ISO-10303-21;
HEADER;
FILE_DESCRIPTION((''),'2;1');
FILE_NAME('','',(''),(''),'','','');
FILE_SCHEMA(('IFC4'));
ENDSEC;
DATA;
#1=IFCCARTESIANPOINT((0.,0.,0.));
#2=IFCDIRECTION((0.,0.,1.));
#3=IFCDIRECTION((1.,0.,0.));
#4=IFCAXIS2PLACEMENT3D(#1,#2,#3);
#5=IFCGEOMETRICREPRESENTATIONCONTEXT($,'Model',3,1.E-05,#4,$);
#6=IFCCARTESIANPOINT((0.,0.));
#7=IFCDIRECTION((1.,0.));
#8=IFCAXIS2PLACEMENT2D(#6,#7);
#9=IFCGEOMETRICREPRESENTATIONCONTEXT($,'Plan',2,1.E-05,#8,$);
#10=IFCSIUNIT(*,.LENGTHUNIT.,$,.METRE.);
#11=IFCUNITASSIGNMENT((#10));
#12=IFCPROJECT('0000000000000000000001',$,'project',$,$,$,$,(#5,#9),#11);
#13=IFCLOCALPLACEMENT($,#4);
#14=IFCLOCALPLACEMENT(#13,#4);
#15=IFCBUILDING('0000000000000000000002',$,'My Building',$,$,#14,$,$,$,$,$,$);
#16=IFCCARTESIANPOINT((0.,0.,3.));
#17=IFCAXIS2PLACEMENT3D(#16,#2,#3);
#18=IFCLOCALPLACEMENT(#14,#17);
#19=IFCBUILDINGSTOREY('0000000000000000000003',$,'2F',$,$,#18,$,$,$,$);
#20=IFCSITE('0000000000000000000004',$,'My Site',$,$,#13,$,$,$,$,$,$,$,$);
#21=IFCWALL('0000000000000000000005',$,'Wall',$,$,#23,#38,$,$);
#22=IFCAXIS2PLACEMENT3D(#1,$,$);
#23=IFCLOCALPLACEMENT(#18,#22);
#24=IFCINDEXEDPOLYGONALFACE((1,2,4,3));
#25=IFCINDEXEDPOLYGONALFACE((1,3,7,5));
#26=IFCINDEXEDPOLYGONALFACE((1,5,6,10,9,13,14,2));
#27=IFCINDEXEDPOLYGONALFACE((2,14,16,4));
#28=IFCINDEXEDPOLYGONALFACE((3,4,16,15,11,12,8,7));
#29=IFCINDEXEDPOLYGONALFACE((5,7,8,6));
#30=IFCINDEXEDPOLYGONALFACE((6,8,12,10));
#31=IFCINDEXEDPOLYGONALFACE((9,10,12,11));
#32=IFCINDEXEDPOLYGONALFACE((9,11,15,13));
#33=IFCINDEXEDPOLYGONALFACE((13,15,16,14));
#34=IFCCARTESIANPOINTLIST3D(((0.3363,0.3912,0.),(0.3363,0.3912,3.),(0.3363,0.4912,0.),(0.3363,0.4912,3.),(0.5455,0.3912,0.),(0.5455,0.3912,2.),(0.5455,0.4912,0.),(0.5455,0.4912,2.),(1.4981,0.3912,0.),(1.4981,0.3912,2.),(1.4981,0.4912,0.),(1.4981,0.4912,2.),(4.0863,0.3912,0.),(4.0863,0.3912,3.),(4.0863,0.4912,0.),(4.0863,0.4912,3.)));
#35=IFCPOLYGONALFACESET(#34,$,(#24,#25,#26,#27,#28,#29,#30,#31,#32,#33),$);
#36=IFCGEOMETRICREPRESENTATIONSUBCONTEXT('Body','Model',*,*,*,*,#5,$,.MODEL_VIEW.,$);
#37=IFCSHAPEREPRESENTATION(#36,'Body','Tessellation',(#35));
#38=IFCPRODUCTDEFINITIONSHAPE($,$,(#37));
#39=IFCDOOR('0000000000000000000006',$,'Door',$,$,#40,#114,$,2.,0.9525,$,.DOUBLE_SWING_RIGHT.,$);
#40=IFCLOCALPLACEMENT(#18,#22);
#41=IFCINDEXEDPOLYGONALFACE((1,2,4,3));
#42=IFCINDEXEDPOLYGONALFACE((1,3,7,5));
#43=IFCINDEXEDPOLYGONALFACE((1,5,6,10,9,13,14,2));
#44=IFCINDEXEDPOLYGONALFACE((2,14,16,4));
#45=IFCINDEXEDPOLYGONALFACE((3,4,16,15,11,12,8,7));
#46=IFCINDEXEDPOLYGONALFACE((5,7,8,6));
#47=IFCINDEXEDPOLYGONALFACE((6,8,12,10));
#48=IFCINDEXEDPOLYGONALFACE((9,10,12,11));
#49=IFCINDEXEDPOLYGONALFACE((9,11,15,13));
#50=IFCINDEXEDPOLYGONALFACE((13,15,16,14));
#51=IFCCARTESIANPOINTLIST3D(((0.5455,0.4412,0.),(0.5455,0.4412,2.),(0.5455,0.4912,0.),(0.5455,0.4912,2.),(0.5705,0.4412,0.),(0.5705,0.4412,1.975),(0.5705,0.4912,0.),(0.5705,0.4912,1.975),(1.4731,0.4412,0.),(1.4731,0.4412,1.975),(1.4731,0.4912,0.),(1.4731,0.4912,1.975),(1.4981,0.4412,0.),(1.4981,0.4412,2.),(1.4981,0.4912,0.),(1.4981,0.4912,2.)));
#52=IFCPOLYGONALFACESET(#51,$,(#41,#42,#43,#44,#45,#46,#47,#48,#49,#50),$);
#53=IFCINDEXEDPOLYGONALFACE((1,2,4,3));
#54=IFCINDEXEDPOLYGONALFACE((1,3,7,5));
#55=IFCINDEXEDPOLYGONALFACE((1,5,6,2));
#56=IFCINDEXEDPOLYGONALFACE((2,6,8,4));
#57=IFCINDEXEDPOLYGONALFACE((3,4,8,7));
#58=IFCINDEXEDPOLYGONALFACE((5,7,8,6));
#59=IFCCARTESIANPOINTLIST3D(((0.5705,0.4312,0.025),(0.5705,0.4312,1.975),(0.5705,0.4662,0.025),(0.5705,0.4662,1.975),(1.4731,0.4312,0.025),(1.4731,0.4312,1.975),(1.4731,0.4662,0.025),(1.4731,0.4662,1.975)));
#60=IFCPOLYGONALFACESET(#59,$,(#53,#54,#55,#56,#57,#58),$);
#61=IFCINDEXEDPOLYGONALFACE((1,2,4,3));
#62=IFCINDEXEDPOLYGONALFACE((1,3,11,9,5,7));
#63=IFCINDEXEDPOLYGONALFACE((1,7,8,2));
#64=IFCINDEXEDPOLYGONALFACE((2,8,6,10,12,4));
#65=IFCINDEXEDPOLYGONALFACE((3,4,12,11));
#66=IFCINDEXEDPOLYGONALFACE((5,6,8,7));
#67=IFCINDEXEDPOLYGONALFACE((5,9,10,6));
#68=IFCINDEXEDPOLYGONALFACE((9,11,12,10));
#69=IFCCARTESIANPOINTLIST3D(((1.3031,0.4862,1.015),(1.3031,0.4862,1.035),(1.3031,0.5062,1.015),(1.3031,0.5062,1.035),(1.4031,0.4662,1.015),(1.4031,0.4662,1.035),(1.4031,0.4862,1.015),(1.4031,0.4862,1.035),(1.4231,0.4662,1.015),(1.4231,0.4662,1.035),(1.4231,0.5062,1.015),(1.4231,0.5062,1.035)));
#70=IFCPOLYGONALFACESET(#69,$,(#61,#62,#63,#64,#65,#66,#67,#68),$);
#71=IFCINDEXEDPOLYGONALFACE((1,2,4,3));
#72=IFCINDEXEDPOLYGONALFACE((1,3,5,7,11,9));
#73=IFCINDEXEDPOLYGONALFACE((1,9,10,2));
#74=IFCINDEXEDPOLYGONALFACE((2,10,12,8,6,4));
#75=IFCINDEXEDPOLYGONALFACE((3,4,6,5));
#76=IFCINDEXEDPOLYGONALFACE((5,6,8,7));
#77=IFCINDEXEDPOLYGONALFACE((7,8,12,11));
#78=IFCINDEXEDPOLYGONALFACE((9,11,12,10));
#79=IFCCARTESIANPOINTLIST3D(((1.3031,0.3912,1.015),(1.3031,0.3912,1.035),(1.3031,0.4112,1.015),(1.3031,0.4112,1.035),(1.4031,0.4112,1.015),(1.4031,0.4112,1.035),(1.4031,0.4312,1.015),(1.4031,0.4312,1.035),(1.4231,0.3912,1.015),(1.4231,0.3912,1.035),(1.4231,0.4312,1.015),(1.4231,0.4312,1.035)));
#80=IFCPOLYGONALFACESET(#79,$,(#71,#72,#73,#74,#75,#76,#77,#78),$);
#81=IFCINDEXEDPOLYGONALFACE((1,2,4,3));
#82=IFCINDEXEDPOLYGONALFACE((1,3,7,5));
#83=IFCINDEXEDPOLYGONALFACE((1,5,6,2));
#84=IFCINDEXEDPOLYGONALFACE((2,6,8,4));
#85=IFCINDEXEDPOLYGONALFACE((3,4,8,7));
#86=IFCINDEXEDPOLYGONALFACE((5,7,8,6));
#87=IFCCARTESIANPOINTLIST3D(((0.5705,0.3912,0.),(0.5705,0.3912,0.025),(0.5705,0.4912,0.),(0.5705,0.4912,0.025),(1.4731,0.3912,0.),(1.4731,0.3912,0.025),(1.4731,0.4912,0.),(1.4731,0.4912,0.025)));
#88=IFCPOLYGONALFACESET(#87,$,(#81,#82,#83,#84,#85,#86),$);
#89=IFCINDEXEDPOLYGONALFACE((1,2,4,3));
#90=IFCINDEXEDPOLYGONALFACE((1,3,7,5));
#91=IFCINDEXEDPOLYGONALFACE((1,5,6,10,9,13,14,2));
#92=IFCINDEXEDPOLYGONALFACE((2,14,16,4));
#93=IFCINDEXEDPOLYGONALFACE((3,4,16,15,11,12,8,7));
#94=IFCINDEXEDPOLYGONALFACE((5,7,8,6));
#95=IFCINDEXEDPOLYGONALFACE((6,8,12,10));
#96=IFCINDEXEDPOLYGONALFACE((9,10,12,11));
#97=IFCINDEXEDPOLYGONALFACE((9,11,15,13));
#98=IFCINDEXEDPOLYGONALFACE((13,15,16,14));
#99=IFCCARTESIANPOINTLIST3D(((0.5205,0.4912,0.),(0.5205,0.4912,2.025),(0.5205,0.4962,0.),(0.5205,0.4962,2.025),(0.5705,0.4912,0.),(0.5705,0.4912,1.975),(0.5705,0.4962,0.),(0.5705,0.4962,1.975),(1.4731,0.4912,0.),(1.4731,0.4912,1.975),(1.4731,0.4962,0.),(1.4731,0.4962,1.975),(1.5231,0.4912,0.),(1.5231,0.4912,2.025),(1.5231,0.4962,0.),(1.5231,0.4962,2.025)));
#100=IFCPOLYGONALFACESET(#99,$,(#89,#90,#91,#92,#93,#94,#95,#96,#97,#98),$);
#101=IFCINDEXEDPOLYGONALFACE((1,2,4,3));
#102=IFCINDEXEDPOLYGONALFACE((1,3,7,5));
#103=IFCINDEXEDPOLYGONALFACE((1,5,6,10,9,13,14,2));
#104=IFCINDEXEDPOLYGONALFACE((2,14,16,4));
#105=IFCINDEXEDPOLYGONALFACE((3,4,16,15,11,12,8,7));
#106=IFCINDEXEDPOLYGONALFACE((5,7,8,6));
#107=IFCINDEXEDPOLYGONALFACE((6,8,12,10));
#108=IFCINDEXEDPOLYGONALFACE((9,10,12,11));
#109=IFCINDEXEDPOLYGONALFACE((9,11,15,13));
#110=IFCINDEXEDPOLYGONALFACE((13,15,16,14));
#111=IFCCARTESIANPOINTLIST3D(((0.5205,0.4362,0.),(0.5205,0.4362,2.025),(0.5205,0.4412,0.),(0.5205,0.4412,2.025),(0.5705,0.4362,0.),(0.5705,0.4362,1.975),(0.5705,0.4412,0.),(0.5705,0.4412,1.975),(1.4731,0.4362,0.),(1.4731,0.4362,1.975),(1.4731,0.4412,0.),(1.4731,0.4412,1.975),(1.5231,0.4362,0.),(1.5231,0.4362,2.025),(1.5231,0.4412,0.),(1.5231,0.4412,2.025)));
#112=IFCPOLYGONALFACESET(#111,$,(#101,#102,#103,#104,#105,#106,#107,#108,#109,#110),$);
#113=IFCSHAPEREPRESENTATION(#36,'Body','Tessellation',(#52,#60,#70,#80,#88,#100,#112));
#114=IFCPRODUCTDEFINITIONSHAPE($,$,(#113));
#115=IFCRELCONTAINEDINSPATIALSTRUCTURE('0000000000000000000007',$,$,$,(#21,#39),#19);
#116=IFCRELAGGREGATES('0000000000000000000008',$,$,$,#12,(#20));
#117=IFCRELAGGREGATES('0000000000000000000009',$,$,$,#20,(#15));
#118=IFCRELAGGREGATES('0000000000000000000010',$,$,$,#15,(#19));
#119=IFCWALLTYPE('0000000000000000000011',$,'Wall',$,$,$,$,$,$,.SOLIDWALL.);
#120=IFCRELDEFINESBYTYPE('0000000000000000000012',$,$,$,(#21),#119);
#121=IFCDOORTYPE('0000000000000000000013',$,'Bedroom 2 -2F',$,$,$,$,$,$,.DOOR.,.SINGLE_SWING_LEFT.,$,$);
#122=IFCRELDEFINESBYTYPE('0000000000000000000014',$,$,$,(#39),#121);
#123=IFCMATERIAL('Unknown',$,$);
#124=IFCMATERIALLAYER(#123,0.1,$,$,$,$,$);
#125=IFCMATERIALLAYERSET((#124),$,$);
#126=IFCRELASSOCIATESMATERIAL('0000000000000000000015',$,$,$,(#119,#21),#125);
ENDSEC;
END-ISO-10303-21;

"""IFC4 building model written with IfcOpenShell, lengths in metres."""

from ifc_helpers import new_model, entity, si_unit, frame, origin_with_axes, origin_2d_with_axis, place, context, subcontext, project, spatial, line, indexed_curve, outline, extrude, shape, source, transform, mapped, material, layer, layer_set, layer_usage, type_object, type_shapes, element, fill, save


model = new_model("IFC4")

# Units and contexts
model_context = context("Model", 3, precision=1e-05, world=origin_with_axes())
plan_context = context("Plan", 2, precision=1e-05, world=origin_2d_with_axis())
body_context_1 = subcontext(model_context, "Body", "Model", "MODEL_VIEW")
body_context_2 = subcontext(plan_context, "Body", "Plan", "PLAN_VIEW")
ifc_project = project(units=[si_unit("LENGTHUNIT", "METRE")], contexts=[model_context, plan_context])

# Site, building, storey
site_placement = place(None, origin_with_axes())
site = spatial("IfcSite", under=ifc_project, at=site_placement, Name="My Site")
building_placement = place(site_placement, origin_with_axes())
building = spatial("IfcBuilding", under=site, at=building_placement, Name="My Building")
storey_placement = place(building_placement, frame((0.0, 0.0, 3.0), z_axis=(0.0, 0.0, 1.0), x_axis=(1.0, 0.0, 0.0)))
storey = spatial("IfcBuildingStorey", under=building, at=storey_placement, Name="2F")

# Shared definitions
ifc_material = material(Name="Unknown")

# Shared definitions
ifc_layer_1 = layer(ifc_material, 0.1)
ifc_layer_set_1 = layer_set([ifc_layer_1])
wall_type = type_object("IfcWallType", Name="Wall", PredefinedType="SOLIDWALL", material=ifc_layer_set_1)

# Shared definitions
shared_shape_1 = source(origin_with_axes(), body_context_1, "Body", "SweptSolid", [
    extrude(outline(indexed_curve([(0.0, 0.0), (0.9525, 0.0), (0.9525, 2.0), (0.0, 2.0)], segments=[line(1, 2, 3, 4, 1)])), frame((0.0, -0.6, 0.0), z_axis=(0.0, -1.0, 0.0), x_axis=(1.0, 0.0, 0.0)), (0.0, 0.0, -1.0), 1.2),
])
door_type_1 = type_object("IfcDoorType", Name="Bedroom 2 -2F", OperationType="SINGLE_SWING_LEFT", PredefinedType="DOOR")
shared_shape_2 = source(origin_with_axes(), body_context_1, "Body", "SweptSolid", [
    extrude(outline(indexed_curve([(0.0, 0.0), (0.0, 2.0), (0.9525, 2.0), (0.9525, 0.0), (0.9275, 0.0), (0.9275, 1.975), (0.025, 1.975), (0.025, 0.0)], segments=[line(1, 2, 3, 4, 5, 6, 7, 8, 1)])), frame((0.0, 0.0, 0.0), z_axis=(0.0, -1.0, 0.0), x_axis=(1.0, 0.0, 0.0)), (0.0, 0.0, -1.0), 0.05),
    extrude(outline(indexed_curve([(0.0, 0.0), (0.9025, 0.0), (0.9025, 0.035), (0.0, 0.035)], segments=[line(1, 2, 3, 4, 1)])), frame((0.025, 0.025, 0.025), z_axis=(0.0, 0.0, 1.0), x_axis=(1.0, 0.0, 0.0)), (0.0, 0.0, 1.0), 1.95),
    extrude(outline(indexed_curve([(0.0, 0.0), (0.0, -0.04), (0.12, -0.04), (0.12, -0.02), (0.02, -0.02), (0.02, 0.0)], segments=[line(1, 2, 3, 4, 5, 6, 1)])), frame((0.075, 0.025, 1.015), z_axis=(0.0, 0.0, 1.0), x_axis=(1.0, 0.0, 0.0)), (0.0, 0.0, 1.0), 0.02),
    extrude(outline(indexed_curve([(0.0, 0.0), (0.0, 0.04), (0.12, 0.04), (0.12, 0.02), (0.02, 0.02), (0.02, 0.0)], segments=[line(1, 2, 3, 4, 5, 6, 1)])), frame((0.075, 0.06, 1.015), z_axis=(0.0, 0.0, 1.0), x_axis=(1.0, 0.0, 0.0)), (0.0, 0.0, 1.0), 0.02),
    extrude(outline(indexed_curve([(0.0, 0.0), (0.9025, 0.0), (0.9025, 0.1), (0.0, 0.1)], segments=[line(1, 2, 3, 4, 1)])), frame((0.025, 0.0, 0.0), z_axis=(0.0, 0.0, 1.0), x_axis=(1.0, 0.0, 0.0)), (0.0, 0.0, 1.0), 0.025),
    extrude(outline(indexed_curve([(0.0, 0.0), (0.0, 2.025), (1.0025, 2.025), (1.0025, 0.0), (0.9525, 0.0), (0.9525, 1.975), (0.05, 1.975), (0.05, 0.0)], segments=[line(1, 2, 3, 4, 5, 6, 7, 8, 1)])), frame((-0.025, -0.005, 0.0), z_axis=(0.0, -1.0, 0.0), x_axis=(1.0, 0.0, 0.0)), (0.0, 0.0, -1.0), 0.005),
    extrude(outline(indexed_curve([(0.0, 0.0), (0.0, 2.025), (1.0025, 2.025), (1.0025, 0.0), (0.9525, 0.0), (0.9525, 1.975), (0.05, 1.975), (0.05, 0.0)], segments=[line(1, 2, 3, 4, 5, 6, 7, 8, 1)])), frame((-0.025, 0.05, 0.0), z_axis=(0.0, -1.0, 0.0), x_axis=(1.0, 0.0, 0.0)), (0.0, 0.0, -1.0), 0.005),
])
shared_shape_3 = source(origin_with_axes(), body_context_2, "Body", "Curve2D", [
    entity("IfcIndexedPolyCurve", entity("IfcCartesianPointList2D", [[0.0, 0.0], [0.025, 0.0], [0.025, 0.05], [0.0, 0.05]]), [entity("IfcLineIndex", [1, 2, 3, 4, 1])]),
    entity("IfcIndexedPolyCurve", entity("IfcCartesianPointList2D", [[0.9525, 0.0], [0.9275, 0.0], [0.9275, 0.05], [0.9525, 0.05]]), [entity("IfcLineIndex", [1, 2, 3, 4, 1])]),
    entity("IfcIndexedPolyCurve", entity("IfcCartesianPointList2D", [[0.9275, 0.05], [0.9275, -0.8525], [0.8925, -0.8525]])),
    entity("IfcTrimmedCurve", entity("IfcEllipse", entity("IfcAxis2Placement2D", entity("IfcCartesianPoint", [0.8925, 0.05]), entity("IfcDirection", [1.0, 0.0])), 0.8675, 0.9025), [entity("IfcCartesianPoint", [0.8925, 0.9525])], [entity("IfcCartesianPoint", [0.8925, -0.8525])], True, "CARTESIAN"),
    entity("IfcIndexedPolyCurve", entity("IfcCartesianPointList2D", [[0.9275, 0.05], [0.8925, 0.05], [0.8925, 0.9525], [0.9275, 0.9525]]), [entity("IfcLineIndex", [1, 2, 3, 4, 1])]),
])
type_shapes(door_type_1, [shared_shape_2, shared_shape_3])

# Wall, opening, door
ifc_layer_usage_1 = layer_usage(ifc_layer_set_1, "AXIS2", "POSITIVE", 0.0)
wall_1_placement = place(storey_placement, frame((4.0863, 0.4912, 0.0), z_axis=(0.0, 0.0, 1.0), x_axis=(-1.0, 0.0, 0.0)))
wall_1 = element("IfcWall", 1, at=wall_1_placement, inside=storey, type_object=wall_type, material=ifc_layer_usage_1, Name="Wall", context=body_context_1, shape_type="SweptSolid", body=[
    extrude(outline(indexed_curve([(0.0, 0.0), (0.0, 0.1), (3.75, 0.1), (3.75, 0.0)], segments=[line(1, 2, 3, 4, 1)])), origin_with_axes(), (0.0, 0.0, 1.0), 3.0),
])
opening_1_placement = place(wall_1_placement, frame((2.5882, 0.0, 0.0), z_axis=(0.0, 0.0, 1.0), x_axis=(1.0, 0.0, 0.0)))
opening_1 = element("IfcOpeningElement", 2, at=opening_1_placement, cuts=wall_1, PredefinedType="OPENING", context=body_context_1, shape_type="MappedRepresentation", body=[
    mapped(shared_shape_1, transform((0.0, 0.0, 0.0), x_axis=(1.0, 0.0, 0.0), y_axis=(0.0, 1.0, 0.0), z_axis=(0.0, 0.0, 1.0), scale=1.0)),
])
door_1_placement = place(opening_1_placement, frame((0.0, 0.0, 0.0), z_axis=(0.0, 0.0, 1.0), x_axis=(1.0, 0.0, 0.0)))
door_1 = element("IfcDoor", 3, at=door_1_placement, inside=storey, type_object=door_type_1, Name="Door", OperationType="DOUBLE_SWING_RIGHT", OverallHeight=2.0, OverallWidth=0.9525, shapes=[
    shape(body_context_1, "Body", "MappedRepresentation", [mapped(shared_shape_2, transform((0.0, 0.0, 0.0), x_axis=(1.0, 0.0, 0.0), y_axis=(0.0, 1.0, 0.0), z_axis=(0.0, 0.0, 1.0), scale=1.0))]),
    shape(body_context_2, "Body", "MappedRepresentation", [mapped(shared_shape_3, transform((0.0, 0.0, 0.0), x_axis=(1.0, 0.0, 0.0), y_axis=(0.0, 1.0, 0.0), z_axis=(0.0, 0.0, 1.0), scale=1.0))]),
])
fill(opening_1, door_1)

save(model, "model.ifc")
